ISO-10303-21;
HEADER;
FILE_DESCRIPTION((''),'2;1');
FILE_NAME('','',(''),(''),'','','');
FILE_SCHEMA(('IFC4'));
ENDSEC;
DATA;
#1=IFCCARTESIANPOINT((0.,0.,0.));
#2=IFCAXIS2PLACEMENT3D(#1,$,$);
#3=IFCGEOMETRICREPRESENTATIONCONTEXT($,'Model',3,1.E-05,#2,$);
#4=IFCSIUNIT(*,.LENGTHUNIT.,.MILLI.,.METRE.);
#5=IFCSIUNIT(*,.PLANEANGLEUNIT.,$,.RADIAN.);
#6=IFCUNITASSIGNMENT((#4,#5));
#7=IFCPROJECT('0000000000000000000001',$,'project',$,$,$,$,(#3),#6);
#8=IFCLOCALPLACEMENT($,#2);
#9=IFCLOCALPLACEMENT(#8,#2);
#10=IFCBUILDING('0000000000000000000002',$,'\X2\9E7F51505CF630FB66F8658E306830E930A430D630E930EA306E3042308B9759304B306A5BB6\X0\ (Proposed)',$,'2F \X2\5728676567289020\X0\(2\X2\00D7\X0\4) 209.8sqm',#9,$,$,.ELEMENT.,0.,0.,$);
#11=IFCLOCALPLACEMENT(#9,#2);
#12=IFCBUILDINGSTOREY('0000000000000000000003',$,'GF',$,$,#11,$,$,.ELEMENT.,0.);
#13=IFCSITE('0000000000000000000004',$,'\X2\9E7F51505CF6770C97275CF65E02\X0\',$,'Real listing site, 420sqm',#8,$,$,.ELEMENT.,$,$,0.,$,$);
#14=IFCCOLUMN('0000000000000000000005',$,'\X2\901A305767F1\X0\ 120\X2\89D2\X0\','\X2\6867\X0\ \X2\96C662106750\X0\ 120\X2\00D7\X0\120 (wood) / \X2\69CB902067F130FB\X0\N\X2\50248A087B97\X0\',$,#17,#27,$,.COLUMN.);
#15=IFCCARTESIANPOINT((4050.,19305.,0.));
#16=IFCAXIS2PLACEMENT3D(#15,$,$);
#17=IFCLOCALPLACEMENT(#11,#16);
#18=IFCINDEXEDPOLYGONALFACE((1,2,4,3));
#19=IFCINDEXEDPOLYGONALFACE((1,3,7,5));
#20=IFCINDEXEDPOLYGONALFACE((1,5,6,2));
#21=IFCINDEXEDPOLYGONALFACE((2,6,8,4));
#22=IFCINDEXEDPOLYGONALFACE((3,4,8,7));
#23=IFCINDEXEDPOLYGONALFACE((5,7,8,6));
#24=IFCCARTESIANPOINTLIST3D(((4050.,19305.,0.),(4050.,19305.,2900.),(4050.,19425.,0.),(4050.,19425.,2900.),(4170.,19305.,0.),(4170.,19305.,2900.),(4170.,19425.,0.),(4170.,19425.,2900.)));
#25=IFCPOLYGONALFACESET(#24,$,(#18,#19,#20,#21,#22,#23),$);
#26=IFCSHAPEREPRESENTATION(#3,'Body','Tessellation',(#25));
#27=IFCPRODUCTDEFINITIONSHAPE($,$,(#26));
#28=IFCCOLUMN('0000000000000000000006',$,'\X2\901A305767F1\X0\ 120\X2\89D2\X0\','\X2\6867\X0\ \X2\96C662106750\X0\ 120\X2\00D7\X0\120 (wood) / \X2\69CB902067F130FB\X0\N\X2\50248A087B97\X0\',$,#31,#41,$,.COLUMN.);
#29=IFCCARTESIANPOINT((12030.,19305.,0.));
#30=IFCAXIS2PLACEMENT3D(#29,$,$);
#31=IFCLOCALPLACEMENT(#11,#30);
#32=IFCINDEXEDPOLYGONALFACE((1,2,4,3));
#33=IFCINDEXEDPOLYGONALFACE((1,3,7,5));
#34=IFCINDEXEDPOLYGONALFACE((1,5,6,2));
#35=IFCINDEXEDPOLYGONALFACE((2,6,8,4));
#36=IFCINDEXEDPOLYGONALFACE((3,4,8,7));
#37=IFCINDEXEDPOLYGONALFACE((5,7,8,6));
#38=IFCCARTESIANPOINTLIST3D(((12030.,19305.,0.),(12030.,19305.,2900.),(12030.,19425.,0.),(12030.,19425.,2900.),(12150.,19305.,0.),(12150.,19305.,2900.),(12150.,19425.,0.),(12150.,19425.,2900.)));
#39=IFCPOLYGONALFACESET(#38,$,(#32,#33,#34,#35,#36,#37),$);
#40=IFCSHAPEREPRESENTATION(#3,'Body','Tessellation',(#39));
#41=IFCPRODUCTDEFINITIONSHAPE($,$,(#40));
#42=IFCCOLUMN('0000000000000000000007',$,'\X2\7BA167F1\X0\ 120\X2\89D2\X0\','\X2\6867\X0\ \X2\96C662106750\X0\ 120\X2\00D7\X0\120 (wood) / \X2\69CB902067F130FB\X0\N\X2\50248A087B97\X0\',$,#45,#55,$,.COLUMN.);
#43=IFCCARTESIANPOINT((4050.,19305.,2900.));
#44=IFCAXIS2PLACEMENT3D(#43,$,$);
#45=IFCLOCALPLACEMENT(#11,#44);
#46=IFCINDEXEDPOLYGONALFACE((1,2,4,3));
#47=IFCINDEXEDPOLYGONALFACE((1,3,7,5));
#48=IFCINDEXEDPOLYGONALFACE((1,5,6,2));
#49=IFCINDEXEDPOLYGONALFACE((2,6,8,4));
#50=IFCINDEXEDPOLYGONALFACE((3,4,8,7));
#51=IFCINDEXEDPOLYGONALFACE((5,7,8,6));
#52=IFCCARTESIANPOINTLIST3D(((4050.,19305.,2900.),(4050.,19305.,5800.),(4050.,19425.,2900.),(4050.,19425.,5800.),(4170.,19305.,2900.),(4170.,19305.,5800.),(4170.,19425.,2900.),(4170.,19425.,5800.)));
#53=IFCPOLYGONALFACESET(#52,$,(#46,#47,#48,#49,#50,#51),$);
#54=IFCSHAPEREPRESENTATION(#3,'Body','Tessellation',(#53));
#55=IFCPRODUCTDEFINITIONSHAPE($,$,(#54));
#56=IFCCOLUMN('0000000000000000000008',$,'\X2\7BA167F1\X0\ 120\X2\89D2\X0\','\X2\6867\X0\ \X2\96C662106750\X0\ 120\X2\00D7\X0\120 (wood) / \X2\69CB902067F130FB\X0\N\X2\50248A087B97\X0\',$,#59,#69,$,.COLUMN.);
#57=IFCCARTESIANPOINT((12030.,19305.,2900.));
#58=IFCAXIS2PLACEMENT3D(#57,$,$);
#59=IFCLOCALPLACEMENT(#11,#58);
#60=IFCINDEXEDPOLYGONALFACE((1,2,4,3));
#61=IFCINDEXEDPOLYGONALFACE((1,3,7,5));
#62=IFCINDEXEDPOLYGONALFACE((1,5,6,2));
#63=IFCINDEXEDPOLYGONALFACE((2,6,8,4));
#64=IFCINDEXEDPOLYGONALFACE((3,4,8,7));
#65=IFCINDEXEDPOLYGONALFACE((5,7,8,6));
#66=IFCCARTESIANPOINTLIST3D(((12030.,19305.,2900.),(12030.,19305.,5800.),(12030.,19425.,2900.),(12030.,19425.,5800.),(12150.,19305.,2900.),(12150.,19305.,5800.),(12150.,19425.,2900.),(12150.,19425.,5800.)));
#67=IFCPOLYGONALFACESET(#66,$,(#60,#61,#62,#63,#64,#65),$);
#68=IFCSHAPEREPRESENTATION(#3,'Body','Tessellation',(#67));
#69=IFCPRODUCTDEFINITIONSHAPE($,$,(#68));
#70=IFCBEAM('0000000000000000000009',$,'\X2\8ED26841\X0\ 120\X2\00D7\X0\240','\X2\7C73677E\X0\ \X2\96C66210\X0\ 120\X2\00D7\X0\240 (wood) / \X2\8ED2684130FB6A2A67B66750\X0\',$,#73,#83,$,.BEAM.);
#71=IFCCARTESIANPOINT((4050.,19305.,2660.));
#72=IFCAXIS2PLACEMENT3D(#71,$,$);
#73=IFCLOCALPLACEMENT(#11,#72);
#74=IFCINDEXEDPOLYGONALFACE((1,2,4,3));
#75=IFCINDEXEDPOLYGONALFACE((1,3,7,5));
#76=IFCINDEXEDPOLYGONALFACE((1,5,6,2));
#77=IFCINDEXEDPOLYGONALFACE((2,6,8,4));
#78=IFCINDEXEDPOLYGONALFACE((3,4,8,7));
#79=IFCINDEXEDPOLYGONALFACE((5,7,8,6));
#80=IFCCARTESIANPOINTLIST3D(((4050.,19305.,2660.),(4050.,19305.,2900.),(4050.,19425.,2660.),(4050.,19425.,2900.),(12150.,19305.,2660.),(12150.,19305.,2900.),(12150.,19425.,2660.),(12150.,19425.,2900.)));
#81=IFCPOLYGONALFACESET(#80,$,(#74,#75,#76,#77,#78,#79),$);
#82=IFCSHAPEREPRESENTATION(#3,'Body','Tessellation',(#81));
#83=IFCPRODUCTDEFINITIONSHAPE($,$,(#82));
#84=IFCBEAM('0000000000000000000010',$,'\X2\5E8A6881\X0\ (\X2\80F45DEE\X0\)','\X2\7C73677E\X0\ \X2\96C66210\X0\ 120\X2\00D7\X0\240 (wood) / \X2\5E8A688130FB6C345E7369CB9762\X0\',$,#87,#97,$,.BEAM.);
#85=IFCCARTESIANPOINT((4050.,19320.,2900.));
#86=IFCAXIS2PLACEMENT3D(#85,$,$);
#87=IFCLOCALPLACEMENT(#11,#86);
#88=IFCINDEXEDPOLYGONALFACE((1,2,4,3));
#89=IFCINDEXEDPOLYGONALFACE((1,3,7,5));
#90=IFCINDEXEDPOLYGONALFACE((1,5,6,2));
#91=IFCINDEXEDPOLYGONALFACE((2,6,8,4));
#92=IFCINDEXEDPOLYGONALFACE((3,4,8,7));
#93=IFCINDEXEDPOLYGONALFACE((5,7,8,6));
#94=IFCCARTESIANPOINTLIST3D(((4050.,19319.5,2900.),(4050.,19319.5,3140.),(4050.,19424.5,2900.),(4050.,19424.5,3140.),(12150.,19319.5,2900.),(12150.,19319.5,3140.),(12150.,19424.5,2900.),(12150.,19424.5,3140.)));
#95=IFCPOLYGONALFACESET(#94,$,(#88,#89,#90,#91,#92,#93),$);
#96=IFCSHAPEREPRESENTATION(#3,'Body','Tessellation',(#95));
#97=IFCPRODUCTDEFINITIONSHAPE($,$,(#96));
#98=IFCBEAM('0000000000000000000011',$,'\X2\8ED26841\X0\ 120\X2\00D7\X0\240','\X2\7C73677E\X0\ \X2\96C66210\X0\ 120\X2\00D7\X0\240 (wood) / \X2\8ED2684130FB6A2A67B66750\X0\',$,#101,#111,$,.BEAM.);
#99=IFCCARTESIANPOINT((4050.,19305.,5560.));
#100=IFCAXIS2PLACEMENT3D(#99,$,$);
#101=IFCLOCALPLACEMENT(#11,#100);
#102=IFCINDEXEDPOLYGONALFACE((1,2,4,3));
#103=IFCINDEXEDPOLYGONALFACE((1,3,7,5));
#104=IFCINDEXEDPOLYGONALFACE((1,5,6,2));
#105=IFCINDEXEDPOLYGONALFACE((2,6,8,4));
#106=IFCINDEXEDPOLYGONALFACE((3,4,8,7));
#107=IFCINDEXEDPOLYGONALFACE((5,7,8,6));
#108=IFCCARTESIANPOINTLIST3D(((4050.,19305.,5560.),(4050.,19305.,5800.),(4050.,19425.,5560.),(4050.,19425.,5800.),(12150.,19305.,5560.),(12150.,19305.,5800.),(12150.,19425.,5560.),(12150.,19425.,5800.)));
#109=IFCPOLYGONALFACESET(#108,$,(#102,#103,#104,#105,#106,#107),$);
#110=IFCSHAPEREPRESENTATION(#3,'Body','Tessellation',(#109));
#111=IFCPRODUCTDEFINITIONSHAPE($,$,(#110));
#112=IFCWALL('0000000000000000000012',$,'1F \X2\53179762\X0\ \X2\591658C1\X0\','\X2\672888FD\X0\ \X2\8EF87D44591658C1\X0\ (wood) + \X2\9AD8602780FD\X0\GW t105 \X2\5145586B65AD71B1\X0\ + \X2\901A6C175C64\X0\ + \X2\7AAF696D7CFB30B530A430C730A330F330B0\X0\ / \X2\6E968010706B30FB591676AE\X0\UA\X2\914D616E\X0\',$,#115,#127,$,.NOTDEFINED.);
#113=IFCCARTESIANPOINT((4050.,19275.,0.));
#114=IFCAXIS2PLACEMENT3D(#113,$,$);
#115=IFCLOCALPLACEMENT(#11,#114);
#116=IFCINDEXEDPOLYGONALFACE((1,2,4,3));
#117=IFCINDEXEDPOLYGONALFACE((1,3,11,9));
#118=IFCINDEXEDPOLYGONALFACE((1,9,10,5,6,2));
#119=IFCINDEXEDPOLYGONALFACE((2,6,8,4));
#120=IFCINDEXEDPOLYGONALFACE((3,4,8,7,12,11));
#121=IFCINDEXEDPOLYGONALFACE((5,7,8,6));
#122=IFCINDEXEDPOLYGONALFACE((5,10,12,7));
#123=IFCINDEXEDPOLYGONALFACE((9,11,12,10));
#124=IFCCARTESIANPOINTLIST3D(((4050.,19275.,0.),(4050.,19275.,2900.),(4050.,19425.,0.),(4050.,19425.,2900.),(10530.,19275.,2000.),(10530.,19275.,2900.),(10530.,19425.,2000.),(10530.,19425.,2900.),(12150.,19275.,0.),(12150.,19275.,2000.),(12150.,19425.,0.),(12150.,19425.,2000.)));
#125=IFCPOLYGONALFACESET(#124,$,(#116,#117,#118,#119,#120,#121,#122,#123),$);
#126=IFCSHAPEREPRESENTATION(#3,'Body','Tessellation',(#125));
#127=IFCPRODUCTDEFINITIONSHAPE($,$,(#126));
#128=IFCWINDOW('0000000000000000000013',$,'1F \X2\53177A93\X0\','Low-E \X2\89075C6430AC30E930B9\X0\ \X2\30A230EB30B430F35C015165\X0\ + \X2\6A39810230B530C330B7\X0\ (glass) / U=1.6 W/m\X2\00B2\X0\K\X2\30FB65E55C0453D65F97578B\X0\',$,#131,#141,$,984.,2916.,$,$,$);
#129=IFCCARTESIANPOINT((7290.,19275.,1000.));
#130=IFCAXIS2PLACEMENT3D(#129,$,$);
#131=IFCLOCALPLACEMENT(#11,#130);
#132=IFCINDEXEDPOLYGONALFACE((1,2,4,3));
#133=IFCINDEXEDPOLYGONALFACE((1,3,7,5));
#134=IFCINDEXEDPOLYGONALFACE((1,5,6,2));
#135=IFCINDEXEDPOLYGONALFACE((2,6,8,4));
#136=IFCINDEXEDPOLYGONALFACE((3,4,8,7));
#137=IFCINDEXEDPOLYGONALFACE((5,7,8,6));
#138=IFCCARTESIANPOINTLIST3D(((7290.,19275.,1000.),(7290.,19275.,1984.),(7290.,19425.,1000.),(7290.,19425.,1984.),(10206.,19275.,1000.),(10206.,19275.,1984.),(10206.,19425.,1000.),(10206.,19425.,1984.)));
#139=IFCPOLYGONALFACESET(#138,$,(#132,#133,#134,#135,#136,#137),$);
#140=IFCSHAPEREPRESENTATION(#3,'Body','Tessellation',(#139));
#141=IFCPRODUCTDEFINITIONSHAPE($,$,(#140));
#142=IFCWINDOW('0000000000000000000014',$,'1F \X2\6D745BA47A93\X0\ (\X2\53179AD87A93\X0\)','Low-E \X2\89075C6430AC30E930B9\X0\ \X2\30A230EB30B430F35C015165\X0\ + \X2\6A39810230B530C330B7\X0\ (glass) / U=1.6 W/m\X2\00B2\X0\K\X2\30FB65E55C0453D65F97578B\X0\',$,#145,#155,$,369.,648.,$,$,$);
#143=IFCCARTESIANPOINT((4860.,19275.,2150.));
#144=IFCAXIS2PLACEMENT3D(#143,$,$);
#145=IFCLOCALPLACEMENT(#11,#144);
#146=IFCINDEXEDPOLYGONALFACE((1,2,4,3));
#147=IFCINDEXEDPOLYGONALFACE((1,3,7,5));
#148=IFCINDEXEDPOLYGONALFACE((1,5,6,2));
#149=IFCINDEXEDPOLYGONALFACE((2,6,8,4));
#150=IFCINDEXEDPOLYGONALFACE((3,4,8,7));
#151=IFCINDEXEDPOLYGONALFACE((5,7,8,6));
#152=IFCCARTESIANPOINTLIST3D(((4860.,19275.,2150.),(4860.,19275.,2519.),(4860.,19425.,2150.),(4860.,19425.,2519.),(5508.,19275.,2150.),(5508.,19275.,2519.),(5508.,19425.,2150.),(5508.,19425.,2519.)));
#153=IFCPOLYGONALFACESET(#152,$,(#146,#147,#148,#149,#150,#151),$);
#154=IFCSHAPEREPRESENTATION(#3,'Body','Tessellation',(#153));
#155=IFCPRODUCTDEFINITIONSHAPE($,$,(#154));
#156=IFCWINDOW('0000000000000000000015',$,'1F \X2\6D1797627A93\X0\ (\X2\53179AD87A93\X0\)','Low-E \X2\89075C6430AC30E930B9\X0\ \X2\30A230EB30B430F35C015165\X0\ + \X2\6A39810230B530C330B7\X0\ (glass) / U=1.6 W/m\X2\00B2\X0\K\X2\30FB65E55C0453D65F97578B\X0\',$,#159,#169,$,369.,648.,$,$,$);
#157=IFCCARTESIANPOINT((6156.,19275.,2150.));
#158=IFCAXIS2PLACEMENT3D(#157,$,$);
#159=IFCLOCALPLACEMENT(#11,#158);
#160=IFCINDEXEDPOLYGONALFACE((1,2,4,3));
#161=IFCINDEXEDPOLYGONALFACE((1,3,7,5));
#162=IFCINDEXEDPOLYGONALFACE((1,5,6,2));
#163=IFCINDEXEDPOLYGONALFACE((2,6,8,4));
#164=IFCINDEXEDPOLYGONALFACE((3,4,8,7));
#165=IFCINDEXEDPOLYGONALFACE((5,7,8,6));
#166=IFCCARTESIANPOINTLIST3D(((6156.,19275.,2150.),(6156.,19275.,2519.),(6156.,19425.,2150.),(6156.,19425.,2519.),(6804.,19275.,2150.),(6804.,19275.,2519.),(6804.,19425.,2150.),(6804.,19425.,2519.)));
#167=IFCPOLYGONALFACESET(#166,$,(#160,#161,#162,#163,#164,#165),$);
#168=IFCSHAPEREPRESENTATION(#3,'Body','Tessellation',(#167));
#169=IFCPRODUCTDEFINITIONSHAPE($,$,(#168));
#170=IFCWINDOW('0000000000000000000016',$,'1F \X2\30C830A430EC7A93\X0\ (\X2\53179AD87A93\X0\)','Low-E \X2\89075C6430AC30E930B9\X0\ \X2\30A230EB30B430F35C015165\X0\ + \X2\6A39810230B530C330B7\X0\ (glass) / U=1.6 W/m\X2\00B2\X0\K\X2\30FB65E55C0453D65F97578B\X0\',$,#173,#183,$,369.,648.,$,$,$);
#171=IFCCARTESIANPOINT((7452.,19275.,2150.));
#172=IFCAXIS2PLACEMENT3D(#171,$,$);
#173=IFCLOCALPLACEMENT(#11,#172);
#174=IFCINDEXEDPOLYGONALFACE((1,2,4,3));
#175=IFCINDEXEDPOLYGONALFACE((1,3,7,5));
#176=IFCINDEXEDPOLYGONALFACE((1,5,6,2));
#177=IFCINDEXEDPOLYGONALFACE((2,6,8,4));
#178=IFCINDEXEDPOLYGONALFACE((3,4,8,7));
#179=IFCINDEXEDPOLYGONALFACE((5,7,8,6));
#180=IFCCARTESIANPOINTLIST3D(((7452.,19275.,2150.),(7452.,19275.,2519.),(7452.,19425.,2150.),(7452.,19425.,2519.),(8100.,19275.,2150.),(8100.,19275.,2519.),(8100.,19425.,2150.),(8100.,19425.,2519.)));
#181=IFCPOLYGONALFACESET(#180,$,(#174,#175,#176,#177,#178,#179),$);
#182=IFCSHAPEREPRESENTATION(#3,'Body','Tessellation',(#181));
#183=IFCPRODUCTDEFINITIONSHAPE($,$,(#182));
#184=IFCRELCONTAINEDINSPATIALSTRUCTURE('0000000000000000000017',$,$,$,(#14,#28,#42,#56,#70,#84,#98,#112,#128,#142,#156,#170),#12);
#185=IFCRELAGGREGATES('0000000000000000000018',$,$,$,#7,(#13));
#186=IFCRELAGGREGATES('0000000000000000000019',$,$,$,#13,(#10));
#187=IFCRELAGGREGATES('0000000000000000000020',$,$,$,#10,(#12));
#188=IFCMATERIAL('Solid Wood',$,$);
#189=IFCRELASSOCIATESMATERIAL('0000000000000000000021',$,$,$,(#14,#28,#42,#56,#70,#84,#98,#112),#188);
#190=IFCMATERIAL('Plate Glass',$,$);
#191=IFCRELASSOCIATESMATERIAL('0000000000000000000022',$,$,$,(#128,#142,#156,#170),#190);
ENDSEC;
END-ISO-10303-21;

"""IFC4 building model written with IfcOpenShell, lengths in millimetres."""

from ifc_helpers import new_model, si_unit, frame, frame_2d, origin, place, context, project, spatial, rectangle, extrude, material, element, fill, save


model = new_model("IFC4")

# Units and contexts
model_context = context("Model", 3, precision=1e-05, world=origin())
ifc_project = project(units=[si_unit("LENGTHUNIT", "METRE", prefix="MILLI"), si_unit("PLANEANGLEUNIT", "RADIAN")], contexts=[model_context])

# Site, building, storey
site_placement = place(None, origin())
site = spatial("IfcSite", under=ifc_project, at=site_placement, Name="鹿児島県霧島市", ObjectType="Real listing site, 420sqm", CompositionType="ELEMENT", RefElevation=0.0)
building_placement = place(site_placement, origin())
building = spatial("IfcBuilding", under=site, at=building_placement, Name="鹿児島・書斎とライブラリのある静かな家 (Proposed)", ObjectType="2F 在来木造(2×4) 209.8sqm", CompositionType="ELEMENT", ElevationOfRefHeight=0.0, ElevationOfTerrain=0.0)
storey_placement = place(building_placement, origin())
storey = spatial("IfcBuildingStorey", under=building, at=storey_placement, Name="GF", CompositionType="ELEMENT", Elevation=0.0)

# Columns
ifc_material_1 = material(Name="Solid Wood")
column_1_placement = place(storey_placement, frame((4050.0, 19305.0, 0.0)))
element("IfcColumn", 1, at=column_1_placement, inside=storey, material=ifc_material_1, Name="通し柱 120角", Description="桧 集成材 120×120 (wood) / 構造柱・N値計算", PredefinedType="COLUMN", context=model_context, shape_type="SweptSolid", body=[
    extrude(rectangle(XDim=120.0, YDim=120.0, at=frame_2d((60.0, 60.0))), frame((4050.0, 19305.0, 0.0)), (0.0, 0.0, 1.0), 2900.0),
])
column_2_placement = place(storey_placement, frame((12030.0, 19305.0, 0.0)))
element("IfcColumn", 2, at=column_2_placement, inside=storey, material=ifc_material_1, Name="通し柱 120角", Description="桧 集成材 120×120 (wood) / 構造柱・N値計算", PredefinedType="COLUMN", context=model_context, shape_type="SweptSolid", body=[
    extrude(rectangle(XDim=120.0, YDim=120.0, at=frame_2d((60.0, 60.0))), frame((12030.0, 19305.0, 0.0)), (0.0, 0.0, 1.0), 2900.0),
])
column_3_placement = place(storey_placement, frame((4050.0, 19305.0, 2900.0)))
element("IfcColumn", 3, at=column_3_placement, inside=storey, material=ifc_material_1, Name="管柱 120角", Description="桧 集成材 120×120 (wood) / 構造柱・N値計算", PredefinedType="COLUMN", context=model_context, shape_type="SweptSolid", body=[
    extrude(rectangle(XDim=120.0, YDim=120.0, at=frame_2d((60.0, 60.0))), frame((4050.0, 19305.0, 2900.0)), (0.0, 0.0, 1.0), 2900.0),
])
column_4_placement = place(storey_placement, frame((12030.0, 19305.0, 2900.0)))
element("IfcColumn", 4, at=column_4_placement, inside=storey, material=ifc_material_1, Name="管柱 120角", Description="桧 集成材 120×120 (wood) / 構造柱・N値計算", PredefinedType="COLUMN", context=model_context, shape_type="SweptSolid", body=[
    extrude(rectangle(XDim=120.0, YDim=120.0, at=frame_2d((60.0, 60.0))), frame((12030.0, 19305.0, 2900.0)), (0.0, 0.0, 1.0), 2900.0),
])

# Beams
beam_1_placement = place(storey_placement, frame((4050.0, 19305.0, 2660.0)))
element("IfcBeam", 5, at=beam_1_placement, inside=storey, material=ifc_material_1, Name="軒桁 120×240", Description="米松 集成 120×240 (wood) / 軒桁・横架材", PredefinedType="BEAM", context=model_context, shape_type="SweptSolid", body=[
    extrude(rectangle(XDim=8100.0, YDim=120.0, at=frame_2d((4050.0, 60.0))), frame((4050.0, 19305.0, 2660.0)), (0.0, 0.0, 1.0), 240.0),
])
beam_2_placement = place(storey_placement, frame((4050.0, 19320.0, 2900.0)))
element("IfcBeam", 6, at=beam_2_placement, inside=storey, material=ifc_material_1, Name="床梁 (胴差)", Description="米松 集成 120×240 (wood) / 床梁・水平構面", PredefinedType="BEAM", context=model_context, shape_type="SweptSolid", body=[
    extrude(rectangle(XDim=8100.0, YDim=105.0, at=frame_2d((4050.0, 52.0))), frame((4050.0, 19320.0, 2900.0)), (0.0, 0.0, 1.0), 240.0),
])
beam_3_placement = place(storey_placement, frame((4050.0, 19305.0, 5560.0)))
element("IfcBeam", 7, at=beam_3_placement, inside=storey, material=ifc_material_1, Name="軒桁 120×240", Description="米松 集成 120×240 (wood) / 軒桁・横架材", PredefinedType="BEAM", context=model_context, shape_type="SweptSolid", body=[
    extrude(rectangle(XDim=8100.0, YDim=120.0, at=frame_2d((4050.0, 60.0))), frame((4050.0, 19305.0, 5560.0)), (0.0, 0.0, 1.0), 240.0),
])

# Wall, openings, windows
wall_1_placement = place(storey_placement, frame((4050.0, 19275.0, 0.0)))
wall_1 = element("IfcWall", 8, at=wall_1_placement, inside=storey, material=ifc_material_1, Name="1F 北面 外壁", Description="木製 軸組外壁 (wood) + 高性能GW t105 充填断熱 + 通気層 + 窯業系サイディング / 準耐火・外皮UA配慮", PredefinedType="NOTDEFINED", context=model_context, shape_type="SweptSolid", body=[
    extrude(rectangle(XDim=8100.0, YDim=150.0, at=frame_2d((4050.0, 75.0))), frame((4050.0, 19275.0, 0.0)), (0.0, 0.0, 1.0), 2900.0),
])
opening_1_placement = place(storey_placement, frame((7290.0, 19275.0, 1000.0)))
opening_1 = element("IfcOpeningElement", 9, at=opening_1_placement, cuts=wall_1, PredefinedType="NOTDEFINED", context=model_context, shape_type="SweptSolid", body=[
    extrude(rectangle(XDim=2916.0, YDim=150.0, at=frame_2d((1458.0, 75.0))), frame((7290.0, 19275.0, 1000.0)), (0.0, 0.0, 1.0), 984.0),
])
opening_2_placement = place(storey_placement, frame((4860.0, 19275.0, 2150.0)))
opening_2 = element("IfcOpeningElement", 10, at=opening_2_placement, cuts=wall_1, PredefinedType="NOTDEFINED", context=model_context, shape_type="SweptSolid", body=[
    extrude(rectangle(XDim=648.0, YDim=150.0, at=frame_2d((324.0, 75.0))), frame((4860.0, 19275.0, 2150.0)), (0.0, 0.0, 1.0), 369.0),
])
opening_3_placement = place(storey_placement, frame((6156.0, 19275.0, 2150.0)))
opening_3 = element("IfcOpeningElement", 11, at=opening_3_placement, cuts=wall_1, PredefinedType="NOTDEFINED", context=model_context, shape_type="SweptSolid", body=[
    extrude(rectangle(XDim=648.0, YDim=150.0, at=frame_2d((324.0, 75.0))), frame((6156.0, 19275.0, 2150.0)), (0.0, 0.0, 1.0), 369.0),
])
opening_4_placement = place(storey_placement, frame((7452.0, 19275.0, 2150.0)))
opening_4 = element("IfcOpeningElement", 12, at=opening_4_placement, cuts=wall_1, PredefinedType="NOTDEFINED", context=model_context, shape_type="SweptSolid", body=[
    extrude(rectangle(XDim=648.0, YDim=150.0, at=frame_2d((324.0, 75.0))), frame((7452.0, 19275.0, 2150.0)), (0.0, 0.0, 1.0), 369.0),
])
ifc_material_2 = material(Name="Plate Glass")
window_1_placement = place(storey_placement, frame((7290.0, 19275.0, 1000.0)))
window_1 = element("IfcWindow", 13, at=window_1_placement, inside=storey, material=ifc_material_2, Name="1F 北窓", Description="Low-E 複層ガラス アルゴン封入 + 樹脂サッシ (glass) / U=1.6 W/m²K・日射取得型", OverallHeight=984.0, OverallWidth=2916.0, context=model_context, shape_type="SweptSolid", body=[
    extrude(rectangle(XDim=2916.0, YDim=150.0, at=frame_2d((1458.0, 75.0))), frame((7290.0, 19275.0, 1000.0)), (0.0, 0.0, 1.0), 984.0),
])
fill(opening_1, window_1)
window_2_placement = place(storey_placement, frame((4860.0, 19275.0, 2150.0)))
window_2 = element("IfcWindow", 14, at=window_2_placement, inside=storey, material=ifc_material_2, Name="1F 浴室窓 (北高窓)", Description="Low-E 複層ガラス アルゴン封入 + 樹脂サッシ (glass) / U=1.6 W/m²K・日射取得型", OverallHeight=369.0, OverallWidth=648.0, context=model_context, shape_type="SweptSolid", body=[
    extrude(rectangle(XDim=648.0, YDim=150.0, at=frame_2d((324.0, 75.0))), frame((4860.0, 19275.0, 2150.0)), (0.0, 0.0, 1.0), 369.0),
])
fill(opening_2, window_2)
window_3_placement = place(storey_placement, frame((6156.0, 19275.0, 2150.0)))
window_3 = element("IfcWindow", 15, at=window_3_placement, inside=storey, material=ifc_material_2, Name="1F 洗面窓 (北高窓)", Description="Low-E 複層ガラス アルゴン封入 + 樹脂サッシ (glass) / U=1.6 W/m²K・日射取得型", OverallHeight=369.0, OverallWidth=648.0, context=model_context, shape_type="SweptSolid", body=[
    extrude(rectangle(XDim=648.0, YDim=150.0, at=frame_2d((324.0, 75.0))), frame((6156.0, 19275.0, 2150.0)), (0.0, 0.0, 1.0), 369.0),
])
fill(opening_3, window_3)
window_4_placement = place(storey_placement, frame((7452.0, 19275.0, 2150.0)))
window_4 = element("IfcWindow", 16, at=window_4_placement, inside=storey, material=ifc_material_2, Name="1F トイレ窓 (北高窓)", Description="Low-E 複層ガラス アルゴン封入 + 樹脂サッシ (glass) / U=1.6 W/m²K・日射取得型", OverallHeight=369.0, OverallWidth=648.0, context=model_context, shape_type="SweptSolid", body=[
    extrude(rectangle(XDim=648.0, YDim=150.0, at=frame_2d((324.0, 75.0))), frame((7452.0, 19275.0, 2150.0)), (0.0, 0.0, 1.0), 369.0),
])
fill(opening_4, window_4)

save(model, "model.ifc")
